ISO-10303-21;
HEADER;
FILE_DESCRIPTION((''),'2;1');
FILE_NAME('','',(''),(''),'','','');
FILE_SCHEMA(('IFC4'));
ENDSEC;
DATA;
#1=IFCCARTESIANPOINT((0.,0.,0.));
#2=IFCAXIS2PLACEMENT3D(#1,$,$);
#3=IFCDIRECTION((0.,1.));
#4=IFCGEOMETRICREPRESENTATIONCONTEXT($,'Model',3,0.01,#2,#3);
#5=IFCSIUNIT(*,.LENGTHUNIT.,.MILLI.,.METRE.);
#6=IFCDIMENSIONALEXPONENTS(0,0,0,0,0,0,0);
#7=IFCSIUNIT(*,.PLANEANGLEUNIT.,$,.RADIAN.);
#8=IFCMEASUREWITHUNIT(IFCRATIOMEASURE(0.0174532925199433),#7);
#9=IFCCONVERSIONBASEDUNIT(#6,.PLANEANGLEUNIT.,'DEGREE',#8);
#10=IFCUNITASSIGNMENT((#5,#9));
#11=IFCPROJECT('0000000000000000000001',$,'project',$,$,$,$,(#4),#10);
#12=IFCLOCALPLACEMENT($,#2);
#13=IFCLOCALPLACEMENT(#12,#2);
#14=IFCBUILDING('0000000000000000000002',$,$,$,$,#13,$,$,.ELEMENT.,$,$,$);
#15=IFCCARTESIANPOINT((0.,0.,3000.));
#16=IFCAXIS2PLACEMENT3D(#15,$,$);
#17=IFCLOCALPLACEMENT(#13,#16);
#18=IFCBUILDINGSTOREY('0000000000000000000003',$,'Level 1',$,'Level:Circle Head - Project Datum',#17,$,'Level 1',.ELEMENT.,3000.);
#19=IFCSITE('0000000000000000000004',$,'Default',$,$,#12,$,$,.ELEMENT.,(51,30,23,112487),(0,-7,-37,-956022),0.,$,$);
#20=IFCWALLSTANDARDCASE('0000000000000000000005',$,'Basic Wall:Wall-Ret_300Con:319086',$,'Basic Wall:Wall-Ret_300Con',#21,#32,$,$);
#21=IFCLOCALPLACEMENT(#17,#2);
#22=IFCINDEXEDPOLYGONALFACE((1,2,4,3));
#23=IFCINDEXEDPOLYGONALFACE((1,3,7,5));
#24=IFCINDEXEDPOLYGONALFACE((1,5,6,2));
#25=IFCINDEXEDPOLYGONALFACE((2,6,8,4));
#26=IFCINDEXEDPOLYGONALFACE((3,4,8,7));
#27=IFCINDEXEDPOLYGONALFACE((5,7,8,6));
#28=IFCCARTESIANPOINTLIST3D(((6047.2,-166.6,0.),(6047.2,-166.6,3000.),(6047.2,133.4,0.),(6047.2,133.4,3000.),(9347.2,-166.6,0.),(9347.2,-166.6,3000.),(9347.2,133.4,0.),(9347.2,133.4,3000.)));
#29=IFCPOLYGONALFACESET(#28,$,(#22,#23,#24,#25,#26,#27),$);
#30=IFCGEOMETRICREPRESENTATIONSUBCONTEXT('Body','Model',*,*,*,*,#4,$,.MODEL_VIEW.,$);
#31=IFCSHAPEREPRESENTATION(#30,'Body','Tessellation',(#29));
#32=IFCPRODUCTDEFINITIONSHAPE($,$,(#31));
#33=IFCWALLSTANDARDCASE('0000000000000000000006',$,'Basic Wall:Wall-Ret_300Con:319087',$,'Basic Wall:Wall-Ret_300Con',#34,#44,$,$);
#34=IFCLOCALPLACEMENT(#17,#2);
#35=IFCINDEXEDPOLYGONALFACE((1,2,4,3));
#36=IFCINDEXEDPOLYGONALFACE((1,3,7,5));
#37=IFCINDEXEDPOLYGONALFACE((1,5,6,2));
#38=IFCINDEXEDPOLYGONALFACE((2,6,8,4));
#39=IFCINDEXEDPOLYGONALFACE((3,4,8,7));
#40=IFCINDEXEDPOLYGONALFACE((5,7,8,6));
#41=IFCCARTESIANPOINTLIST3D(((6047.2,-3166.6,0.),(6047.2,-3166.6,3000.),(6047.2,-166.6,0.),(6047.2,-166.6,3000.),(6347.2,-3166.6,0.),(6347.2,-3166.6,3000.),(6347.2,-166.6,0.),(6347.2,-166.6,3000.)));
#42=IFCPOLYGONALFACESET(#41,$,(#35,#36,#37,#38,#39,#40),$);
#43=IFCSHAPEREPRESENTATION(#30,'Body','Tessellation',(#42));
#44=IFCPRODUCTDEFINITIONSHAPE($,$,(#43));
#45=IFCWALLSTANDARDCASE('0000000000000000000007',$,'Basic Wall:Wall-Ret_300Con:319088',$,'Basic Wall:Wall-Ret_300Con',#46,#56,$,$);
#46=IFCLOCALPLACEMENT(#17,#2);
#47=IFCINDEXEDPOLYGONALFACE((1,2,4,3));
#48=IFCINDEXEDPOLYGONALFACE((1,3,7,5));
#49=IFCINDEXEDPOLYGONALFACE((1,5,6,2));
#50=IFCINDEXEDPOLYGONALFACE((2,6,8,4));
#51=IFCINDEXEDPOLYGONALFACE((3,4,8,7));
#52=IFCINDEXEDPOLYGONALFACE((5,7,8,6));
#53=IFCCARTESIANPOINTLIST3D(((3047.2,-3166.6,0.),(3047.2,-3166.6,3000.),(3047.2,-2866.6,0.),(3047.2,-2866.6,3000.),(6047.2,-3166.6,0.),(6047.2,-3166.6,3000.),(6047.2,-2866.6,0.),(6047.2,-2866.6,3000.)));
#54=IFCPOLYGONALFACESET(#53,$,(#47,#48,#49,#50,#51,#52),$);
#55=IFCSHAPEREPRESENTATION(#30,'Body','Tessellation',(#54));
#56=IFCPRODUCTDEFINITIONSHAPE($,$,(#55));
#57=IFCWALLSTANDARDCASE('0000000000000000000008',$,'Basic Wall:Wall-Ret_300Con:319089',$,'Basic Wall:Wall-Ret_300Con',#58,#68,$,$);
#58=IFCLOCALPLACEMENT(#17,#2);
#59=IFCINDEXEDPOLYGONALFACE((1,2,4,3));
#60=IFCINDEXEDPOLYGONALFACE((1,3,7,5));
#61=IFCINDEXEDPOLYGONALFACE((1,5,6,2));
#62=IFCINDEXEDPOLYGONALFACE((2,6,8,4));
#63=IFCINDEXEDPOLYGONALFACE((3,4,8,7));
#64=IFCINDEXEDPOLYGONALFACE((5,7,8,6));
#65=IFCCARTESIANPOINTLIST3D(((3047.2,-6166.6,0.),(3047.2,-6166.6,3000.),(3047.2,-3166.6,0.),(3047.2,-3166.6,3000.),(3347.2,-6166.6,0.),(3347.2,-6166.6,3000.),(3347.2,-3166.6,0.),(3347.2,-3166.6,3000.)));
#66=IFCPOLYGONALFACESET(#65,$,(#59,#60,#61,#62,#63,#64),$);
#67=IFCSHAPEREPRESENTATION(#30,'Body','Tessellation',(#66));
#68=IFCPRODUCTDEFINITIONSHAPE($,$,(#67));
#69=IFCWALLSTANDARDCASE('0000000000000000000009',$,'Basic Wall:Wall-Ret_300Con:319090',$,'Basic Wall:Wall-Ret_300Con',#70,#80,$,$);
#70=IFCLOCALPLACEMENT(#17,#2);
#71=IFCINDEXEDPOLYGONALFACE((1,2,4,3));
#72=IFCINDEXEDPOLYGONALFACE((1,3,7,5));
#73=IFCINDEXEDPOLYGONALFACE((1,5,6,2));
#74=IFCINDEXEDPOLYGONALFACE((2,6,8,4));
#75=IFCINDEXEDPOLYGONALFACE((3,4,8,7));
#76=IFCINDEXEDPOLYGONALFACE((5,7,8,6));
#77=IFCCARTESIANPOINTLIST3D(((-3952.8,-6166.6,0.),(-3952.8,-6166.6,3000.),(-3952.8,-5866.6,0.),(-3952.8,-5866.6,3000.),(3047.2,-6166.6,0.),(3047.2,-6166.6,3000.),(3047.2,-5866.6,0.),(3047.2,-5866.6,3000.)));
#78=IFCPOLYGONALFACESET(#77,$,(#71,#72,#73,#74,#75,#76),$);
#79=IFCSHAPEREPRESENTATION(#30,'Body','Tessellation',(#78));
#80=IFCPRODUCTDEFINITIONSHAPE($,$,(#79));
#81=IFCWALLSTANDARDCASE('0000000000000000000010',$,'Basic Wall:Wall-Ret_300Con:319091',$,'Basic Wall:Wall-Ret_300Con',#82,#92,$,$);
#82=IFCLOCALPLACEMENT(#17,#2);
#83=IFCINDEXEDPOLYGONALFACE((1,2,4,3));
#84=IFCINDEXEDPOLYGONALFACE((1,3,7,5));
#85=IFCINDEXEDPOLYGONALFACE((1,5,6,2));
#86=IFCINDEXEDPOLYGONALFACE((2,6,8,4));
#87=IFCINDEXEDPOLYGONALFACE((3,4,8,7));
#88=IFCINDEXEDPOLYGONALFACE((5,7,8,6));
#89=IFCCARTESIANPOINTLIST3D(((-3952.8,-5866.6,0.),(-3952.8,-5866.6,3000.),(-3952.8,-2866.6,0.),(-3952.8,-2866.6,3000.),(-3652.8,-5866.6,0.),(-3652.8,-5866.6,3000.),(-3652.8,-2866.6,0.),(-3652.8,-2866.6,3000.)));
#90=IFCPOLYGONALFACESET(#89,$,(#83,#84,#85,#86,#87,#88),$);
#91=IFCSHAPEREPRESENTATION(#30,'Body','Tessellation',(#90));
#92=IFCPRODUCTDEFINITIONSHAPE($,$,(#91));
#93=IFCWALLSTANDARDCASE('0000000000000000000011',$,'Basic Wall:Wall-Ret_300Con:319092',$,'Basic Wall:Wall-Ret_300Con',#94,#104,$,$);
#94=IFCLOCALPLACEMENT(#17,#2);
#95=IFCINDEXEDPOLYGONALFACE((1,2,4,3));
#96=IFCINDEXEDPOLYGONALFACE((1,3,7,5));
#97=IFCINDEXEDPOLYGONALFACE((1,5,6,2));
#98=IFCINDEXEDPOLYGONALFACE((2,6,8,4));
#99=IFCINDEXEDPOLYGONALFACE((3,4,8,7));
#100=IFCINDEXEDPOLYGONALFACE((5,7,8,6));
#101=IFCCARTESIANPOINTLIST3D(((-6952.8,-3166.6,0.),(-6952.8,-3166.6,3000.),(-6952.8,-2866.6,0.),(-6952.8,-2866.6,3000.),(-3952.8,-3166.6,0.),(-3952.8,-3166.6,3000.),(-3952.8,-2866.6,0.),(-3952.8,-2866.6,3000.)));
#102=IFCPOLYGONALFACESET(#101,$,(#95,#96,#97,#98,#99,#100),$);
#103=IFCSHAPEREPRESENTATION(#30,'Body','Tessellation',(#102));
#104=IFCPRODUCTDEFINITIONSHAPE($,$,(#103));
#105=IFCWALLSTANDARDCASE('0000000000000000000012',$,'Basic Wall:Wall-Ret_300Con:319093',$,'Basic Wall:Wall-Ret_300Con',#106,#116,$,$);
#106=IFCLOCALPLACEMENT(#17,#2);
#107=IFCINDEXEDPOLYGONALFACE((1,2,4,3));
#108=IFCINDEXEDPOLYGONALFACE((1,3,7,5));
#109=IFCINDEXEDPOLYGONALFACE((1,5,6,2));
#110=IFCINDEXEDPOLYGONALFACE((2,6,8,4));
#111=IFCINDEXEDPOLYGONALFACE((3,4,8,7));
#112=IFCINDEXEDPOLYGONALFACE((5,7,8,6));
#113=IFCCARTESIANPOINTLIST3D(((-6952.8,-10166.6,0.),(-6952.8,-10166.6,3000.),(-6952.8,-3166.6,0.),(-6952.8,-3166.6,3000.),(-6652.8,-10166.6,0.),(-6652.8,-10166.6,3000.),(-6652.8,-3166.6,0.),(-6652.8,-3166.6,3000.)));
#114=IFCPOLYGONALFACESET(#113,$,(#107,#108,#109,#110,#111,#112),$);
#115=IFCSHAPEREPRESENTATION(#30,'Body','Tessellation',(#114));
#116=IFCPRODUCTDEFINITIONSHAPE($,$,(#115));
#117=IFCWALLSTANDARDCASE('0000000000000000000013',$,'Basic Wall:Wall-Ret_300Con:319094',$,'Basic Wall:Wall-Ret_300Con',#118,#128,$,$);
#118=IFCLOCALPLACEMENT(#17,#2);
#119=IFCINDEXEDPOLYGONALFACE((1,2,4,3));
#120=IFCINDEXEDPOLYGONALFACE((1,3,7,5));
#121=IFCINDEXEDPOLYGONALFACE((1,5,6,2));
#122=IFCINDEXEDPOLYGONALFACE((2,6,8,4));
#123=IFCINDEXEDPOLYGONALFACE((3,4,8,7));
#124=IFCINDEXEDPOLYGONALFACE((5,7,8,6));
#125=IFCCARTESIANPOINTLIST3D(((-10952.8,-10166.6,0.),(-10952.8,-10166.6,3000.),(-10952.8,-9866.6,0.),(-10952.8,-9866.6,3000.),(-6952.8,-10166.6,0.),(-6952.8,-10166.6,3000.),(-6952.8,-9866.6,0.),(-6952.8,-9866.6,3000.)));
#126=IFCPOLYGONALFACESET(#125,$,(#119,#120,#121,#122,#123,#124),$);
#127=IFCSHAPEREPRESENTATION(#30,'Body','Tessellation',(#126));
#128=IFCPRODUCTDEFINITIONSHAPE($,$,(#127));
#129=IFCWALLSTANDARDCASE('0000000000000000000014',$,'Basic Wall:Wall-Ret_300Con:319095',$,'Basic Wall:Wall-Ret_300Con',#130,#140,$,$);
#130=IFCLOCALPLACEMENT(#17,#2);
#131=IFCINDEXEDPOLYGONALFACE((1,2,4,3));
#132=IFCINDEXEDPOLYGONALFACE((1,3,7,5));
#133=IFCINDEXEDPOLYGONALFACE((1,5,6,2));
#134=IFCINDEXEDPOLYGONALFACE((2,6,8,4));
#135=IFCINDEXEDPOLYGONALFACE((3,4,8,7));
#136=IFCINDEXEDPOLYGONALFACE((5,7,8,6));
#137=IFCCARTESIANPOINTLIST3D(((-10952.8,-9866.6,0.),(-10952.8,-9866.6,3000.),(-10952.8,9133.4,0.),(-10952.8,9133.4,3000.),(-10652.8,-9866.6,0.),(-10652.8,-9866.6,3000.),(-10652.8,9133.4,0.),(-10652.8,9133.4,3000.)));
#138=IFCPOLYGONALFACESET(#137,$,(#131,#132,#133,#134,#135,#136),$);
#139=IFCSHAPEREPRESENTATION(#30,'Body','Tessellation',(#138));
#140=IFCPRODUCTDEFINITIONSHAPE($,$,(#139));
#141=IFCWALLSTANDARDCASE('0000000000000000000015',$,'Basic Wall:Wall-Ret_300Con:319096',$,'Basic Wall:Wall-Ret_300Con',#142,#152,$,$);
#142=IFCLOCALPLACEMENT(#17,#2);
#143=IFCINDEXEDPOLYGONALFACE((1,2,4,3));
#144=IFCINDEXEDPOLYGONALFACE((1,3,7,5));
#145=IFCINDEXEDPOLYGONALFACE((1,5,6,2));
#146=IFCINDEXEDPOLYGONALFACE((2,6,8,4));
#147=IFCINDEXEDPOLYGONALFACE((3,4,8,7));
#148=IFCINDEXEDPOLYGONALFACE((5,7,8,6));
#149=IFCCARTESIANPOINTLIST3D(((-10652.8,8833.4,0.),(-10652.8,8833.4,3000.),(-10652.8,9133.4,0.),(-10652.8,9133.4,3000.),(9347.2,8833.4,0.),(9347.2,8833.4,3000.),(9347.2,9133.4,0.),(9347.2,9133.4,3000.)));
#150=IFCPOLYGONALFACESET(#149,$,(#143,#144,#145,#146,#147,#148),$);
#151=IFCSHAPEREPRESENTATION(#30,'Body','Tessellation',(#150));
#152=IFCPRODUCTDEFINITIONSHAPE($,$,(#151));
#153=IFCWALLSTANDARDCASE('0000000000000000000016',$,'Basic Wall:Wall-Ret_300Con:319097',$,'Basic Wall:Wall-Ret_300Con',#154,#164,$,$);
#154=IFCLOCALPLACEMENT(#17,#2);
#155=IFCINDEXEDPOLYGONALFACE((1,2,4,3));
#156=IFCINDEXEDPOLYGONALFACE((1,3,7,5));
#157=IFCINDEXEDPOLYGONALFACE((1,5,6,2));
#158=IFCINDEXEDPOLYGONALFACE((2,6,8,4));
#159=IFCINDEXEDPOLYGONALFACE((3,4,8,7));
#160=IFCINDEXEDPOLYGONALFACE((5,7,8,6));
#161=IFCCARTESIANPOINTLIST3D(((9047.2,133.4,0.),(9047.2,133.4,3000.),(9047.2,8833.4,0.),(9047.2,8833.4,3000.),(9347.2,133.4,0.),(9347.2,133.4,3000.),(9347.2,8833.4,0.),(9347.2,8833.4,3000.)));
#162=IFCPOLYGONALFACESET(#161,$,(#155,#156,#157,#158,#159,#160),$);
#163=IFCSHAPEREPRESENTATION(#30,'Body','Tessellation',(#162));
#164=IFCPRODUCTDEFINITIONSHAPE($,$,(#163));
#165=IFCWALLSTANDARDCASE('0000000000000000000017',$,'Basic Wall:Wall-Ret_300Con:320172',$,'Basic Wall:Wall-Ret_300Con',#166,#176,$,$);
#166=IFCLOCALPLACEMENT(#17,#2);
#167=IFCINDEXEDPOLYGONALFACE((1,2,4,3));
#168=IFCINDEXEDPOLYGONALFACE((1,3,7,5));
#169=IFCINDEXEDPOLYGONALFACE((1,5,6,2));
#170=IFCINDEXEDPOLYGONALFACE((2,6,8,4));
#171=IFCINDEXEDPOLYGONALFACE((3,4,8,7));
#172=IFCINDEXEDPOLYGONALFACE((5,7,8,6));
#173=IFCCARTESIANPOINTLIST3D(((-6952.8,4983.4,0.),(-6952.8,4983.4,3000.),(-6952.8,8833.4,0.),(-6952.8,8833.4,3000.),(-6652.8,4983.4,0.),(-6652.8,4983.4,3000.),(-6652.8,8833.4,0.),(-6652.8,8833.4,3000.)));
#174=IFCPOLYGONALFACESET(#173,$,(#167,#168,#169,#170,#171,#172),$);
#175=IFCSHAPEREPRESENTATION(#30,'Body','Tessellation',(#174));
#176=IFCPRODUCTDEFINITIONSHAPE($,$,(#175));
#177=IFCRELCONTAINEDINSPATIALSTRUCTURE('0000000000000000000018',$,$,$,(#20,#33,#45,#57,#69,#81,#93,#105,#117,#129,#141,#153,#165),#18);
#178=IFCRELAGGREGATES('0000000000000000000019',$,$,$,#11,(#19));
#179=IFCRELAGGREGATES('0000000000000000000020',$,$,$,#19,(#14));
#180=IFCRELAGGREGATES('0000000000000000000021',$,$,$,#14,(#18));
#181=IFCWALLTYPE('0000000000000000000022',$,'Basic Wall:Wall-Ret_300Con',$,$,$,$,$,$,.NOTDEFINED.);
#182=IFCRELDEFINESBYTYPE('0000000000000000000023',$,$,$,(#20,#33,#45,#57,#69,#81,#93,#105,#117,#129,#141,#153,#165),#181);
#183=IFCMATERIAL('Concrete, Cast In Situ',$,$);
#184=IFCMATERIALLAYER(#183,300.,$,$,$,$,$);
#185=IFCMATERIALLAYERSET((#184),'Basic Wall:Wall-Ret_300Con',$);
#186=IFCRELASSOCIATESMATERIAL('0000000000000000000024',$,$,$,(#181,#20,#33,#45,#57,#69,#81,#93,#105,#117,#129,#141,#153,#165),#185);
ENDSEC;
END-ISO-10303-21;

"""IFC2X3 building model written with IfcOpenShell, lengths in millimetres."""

from ifc_helpers import new_model, entity, si_unit, converted_unit, direction, frame, frame_2d, origin, place, context, subcontext, project, spatial, rectangle, extrude, material, layer, layer_set, layer_usage, type_object, element, save


model = new_model("IFC2X3")

# Units and contexts
model_context = context("Model", 3, precision=0.01, world=origin(), true_north=direction((0.0, 1.0)))
body_context = subcontext(model_context, "Body", "Model", "MODEL_VIEW")
ifc_project = project(units=[si_unit("LENGTHUNIT", "METRE", prefix="MILLI"), converted_unit("PLANEANGLEUNIT", "DEGREE", entity("IfcRatioMeasure", 0.0174532925199433), si_unit("PLANEANGLEUNIT", "RADIAN"), dimensions=[0, 0, 0, 0, 0, 0, 0])], contexts=[model_context])

# Site, building, storey
site_placement = place(None, origin())
site = spatial("IfcSite", under=ifc_project, at=site_placement, Name="Default", CompositionType="ELEMENT", RefLatitude=(51, 30, 23, 112487), RefLongitude=(0, -7, -37, -956022), RefElevation=0.0)
building_placement = place(site_placement, origin())
building = spatial("IfcBuilding", under=site, at=building_placement, CompositionType="ELEMENT")
storey_placement = place(building_placement, frame((0.0, 0.0, 3000.0)))
storey = spatial("IfcBuildingStorey", under=building, at=storey_placement, Name="Level 1", ObjectType="Level:Circle Head - Project Datum", LongName="Level 1", CompositionType="ELEMENT", Elevation=3000.0)

# Walls
ifc_material_1 = material(Name="Concrete, Cast In Situ")
ifc_layer_1 = layer(ifc_material_1, 300.0)
ifc_layer_set_1 = layer_set([ifc_layer_1], Name="Basic Wall:Wall-Ret_300Con")
ifc_layer_usage_1 = layer_usage(ifc_layer_set_1, "AXIS2", "NEGATIVE", 150.0)
wall_type = type_object("IfcWallType", Name="Basic Wall:Wall-Ret_300Con", PredefinedType="NOTDEFINED", material=ifc_layer_set_1)
wall_1_placement = place(storey_placement, frame((9347.2, -16.6, 0.0), z_axis=(0.0, 0.0, 1.0), x_axis=(-1.0, 0.0, 0.0)))
element("IfcWallStandardCase", 1, at=wall_1_placement, inside=storey, type_object=wall_type, material=ifc_layer_usage_1, Name="Basic Wall:Wall-Ret_300Con:319086", ObjectType="Basic Wall:Wall-Ret_300Con", context=body_context, shape_type="SweptSolid", body=[
    extrude(rectangle(XDim=3300.0, YDim=300.0, at=frame_2d((1650.0, 0.0), x_axis=(-1.0, 0.0))), origin(), (0.0, 0.0, 1.0), 3000.0),
])
ifc_layer_usage_2 = layer_usage(ifc_layer_set_1, "AXIS2", "NEGATIVE", 150.0)
wall_2_placement = place(storey_placement, frame((6197.2, -166.6, 0.0), z_axis=(0.0, 0.0, 1.0), x_axis=(0.0, -1.0, 0.0)))
element("IfcWallStandardCase", 2, at=wall_2_placement, inside=storey, type_object=wall_type, material=ifc_layer_usage_2, Name="Basic Wall:Wall-Ret_300Con:319087", ObjectType="Basic Wall:Wall-Ret_300Con", context=body_context, shape_type="SweptSolid", body=[
    extrude(rectangle(XDim=3000.0, YDim=300.0, at=frame_2d((1500.0, 0.0), x_axis=(-1.0, 0.0))), origin(), (0.0, 0.0, 1.0), 3000.0),
])
ifc_layer_usage_3 = layer_usage(ifc_layer_set_1, "AXIS2", "NEGATIVE", 150.0)
wall_3_placement = place(storey_placement, frame((6047.2, -3016.6, 0.0), z_axis=(0.0, 0.0, 1.0), x_axis=(-1.0, 0.0, 0.0)))
element("IfcWallStandardCase", 3, at=wall_3_placement, inside=storey, type_object=wall_type, material=ifc_layer_usage_3, Name="Basic Wall:Wall-Ret_300Con:319088", ObjectType="Basic Wall:Wall-Ret_300Con", context=body_context, shape_type="SweptSolid", body=[
    extrude(rectangle(XDim=3000.0, YDim=300.0, at=frame_2d((1500.0, 0.0), x_axis=(-1.0, 0.0))), origin(), (0.0, 0.0, 1.0), 3000.0),
])
ifc_layer_usage_4 = layer_usage(ifc_layer_set_1, "AXIS2", "NEGATIVE", 150.0)
wall_4_placement = place(storey_placement, frame((3197.2, -3166.6, 0.0), z_axis=(0.0, 0.0, 1.0), x_axis=(0.0, -1.0, 0.0)))
element("IfcWallStandardCase", 4, at=wall_4_placement, inside=storey, type_object=wall_type, material=ifc_layer_usage_4, Name="Basic Wall:Wall-Ret_300Con:319089", ObjectType="Basic Wall:Wall-Ret_300Con", context=body_context, shape_type="SweptSolid", body=[
    extrude(rectangle(XDim=3000.0, YDim=300.0, at=frame_2d((1500.0, 0.0), x_axis=(-1.0, 0.0))), origin(), (0.0, 0.0, 1.0), 3000.0),
])
ifc_layer_usage_5 = layer_usage(ifc_layer_set_1, "AXIS2", "NEGATIVE", 150.0)
wall_5_placement = place(storey_placement, frame((3047.2, -6016.6, 0.0), z_axis=(0.0, 0.0, 1.0), x_axis=(-1.0, 0.0, 0.0)))
element("IfcWallStandardCase", 5, at=wall_5_placement, inside=storey, type_object=wall_type, material=ifc_layer_usage_5, Name="Basic Wall:Wall-Ret_300Con:319090", ObjectType="Basic Wall:Wall-Ret_300Con", context=body_context, shape_type="SweptSolid", body=[
    extrude(rectangle(XDim=7000.0, YDim=300.0, at=frame_2d((3500.0, 0.0), x_axis=(-1.0, 0.0))), origin(), (0.0, 0.0, 1.0), 3000.0),
])
ifc_layer_usage_6 = layer_usage(ifc_layer_set_1, "AXIS2", "NEGATIVE", 150.0)
wall_6_placement = place(storey_placement, frame((-3802.8, -5866.6, 0.0), z_axis=(0.0, 0.0, 1.0), x_axis=(0.0, 1.0, 0.0)))
element("IfcWallStandardCase", 6, at=wall_6_placement, inside=storey, type_object=wall_type, material=ifc_layer_usage_6, Name="Basic Wall:Wall-Ret_300Con:319091", ObjectType="Basic Wall:Wall-Ret_300Con", context=body_context, shape_type="SweptSolid", body=[
    extrude(rectangle(XDim=3000.0, YDim=300.0, at=frame_2d((1500.0, 0.0), x_axis=(-1.0, 0.0))), origin(), (0.0, 0.0, 1.0), 3000.0),
])
ifc_layer_usage_7 = layer_usage(ifc_layer_set_1, "AXIS2", "NEGATIVE", 150.0)
wall_7_placement = place(storey_placement, frame((-3952.8, -3016.6, 0.0), z_axis=(0.0, 0.0, 1.0), x_axis=(-1.0, 0.0, 0.0)))
element("IfcWallStandardCase", 7, at=wall_7_placement, inside=storey, type_object=wall_type, material=ifc_layer_usage_7, Name="Basic Wall:Wall-Ret_300Con:319092", ObjectType="Basic Wall:Wall-Ret_300Con", context=body_context, shape_type="SweptSolid", body=[
    extrude(rectangle(XDim=3000.0, YDim=300.0, at=frame_2d((1500.0, 0.0), x_axis=(-1.0, 0.0))), origin(), (0.0, 0.0, 1.0), 3000.0),
])
ifc_layer_usage_8 = layer_usage(ifc_layer_set_1, "AXIS2", "NEGATIVE", 150.0)
wall_8_placement = place(storey_placement, frame((-6802.8, -3166.6, 0.0), z_axis=(0.0, 0.0, 1.0), x_axis=(0.0, -1.0, 0.0)))
element("IfcWallStandardCase", 8, at=wall_8_placement, inside=storey, type_object=wall_type, material=ifc_layer_usage_8, Name="Basic Wall:Wall-Ret_300Con:319093", ObjectType="Basic Wall:Wall-Ret_300Con", context=body_context, shape_type="SweptSolid", body=[
    extrude(rectangle(XDim=7000.0, YDim=300.0, at=frame_2d((3500.0, 0.0), x_axis=(-1.0, 0.0))), origin(), (0.0, 0.0, 1.0), 3000.0),
])
ifc_layer_usage_9 = layer_usage(ifc_layer_set_1, "AXIS2", "NEGATIVE", 150.0)
wall_9_placement = place(storey_placement, frame((-6952.8, -10016.6, 0.0), z_axis=(0.0, 0.0, 1.0), x_axis=(-1.0, 0.0, 0.0)))
element("IfcWallStandardCase", 9, at=wall_9_placement, inside=storey, type_object=wall_type, material=ifc_layer_usage_9, Name="Basic Wall:Wall-Ret_300Con:319094", ObjectType="Basic Wall:Wall-Ret_300Con", context=body_context, shape_type="SweptSolid", body=[
    extrude(rectangle(XDim=4000.0, YDim=300.0, at=frame_2d((2000.0, 0.0), x_axis=(-1.0, 0.0))), origin(), (0.0, 0.0, 1.0), 3000.0),
])
ifc_layer_usage_10 = layer_usage(ifc_layer_set_1, "AXIS2", "NEGATIVE", 150.0)
wall_10_placement = place(storey_placement, frame((-10802.8, -9866.6, 0.0), z_axis=(0.0, 0.0, 1.0), x_axis=(0.0, 1.0, 0.0)))
element("IfcWallStandardCase", 10, at=wall_10_placement, inside=storey, type_object=wall_type, material=ifc_layer_usage_10, Name="Basic Wall:Wall-Ret_300Con:319095", ObjectType="Basic Wall:Wall-Ret_300Con", context=body_context, shape_type="SweptSolid", body=[
    extrude(rectangle(XDim=19000.0, YDim=300.0, at=frame_2d((9500.0, 0.0), x_axis=(-1.0, 0.0))), origin(), (0.0, 0.0, 1.0), 3000.0),
])
ifc_layer_usage_11 = layer_usage(ifc_layer_set_1, "AXIS2", "NEGATIVE", 150.0)
wall_11_placement = place(storey_placement, frame((-10652.8, 8983.4, 0.0)))
element("IfcWallStandardCase", 11, at=wall_11_placement, inside=storey, type_object=wall_type, material=ifc_layer_usage_11, Name="Basic Wall:Wall-Ret_300Con:319096", ObjectType="Basic Wall:Wall-Ret_300Con", context=body_context, shape_type="SweptSolid", body=[
    extrude(rectangle(XDim=20000.0, YDim=300.0, at=frame_2d((10000.0, 0.0), x_axis=(-1.0, 0.0))), origin(), (0.0, 0.0, 1.0), 3000.0),
])
ifc_layer_usage_12 = layer_usage(ifc_layer_set_1, "AXIS2", "NEGATIVE", 150.0)
wall_12_placement = place(storey_placement, frame((9197.2, 8833.4, 0.0), z_axis=(0.0, 0.0, 1.0), x_axis=(0.0, -1.0, 0.0)))
element("IfcWallStandardCase", 12, at=wall_12_placement, inside=storey, type_object=wall_type, material=ifc_layer_usage_12, Name="Basic Wall:Wall-Ret_300Con:319097", ObjectType="Basic Wall:Wall-Ret_300Con", context=body_context, shape_type="SweptSolid", body=[
    extrude(rectangle(XDim=8700.0, YDim=300.0, at=frame_2d((4350.0, 0.0), x_axis=(-1.0, 0.0))), origin(), (0.0, 0.0, 1.0), 3000.0),
])
ifc_layer_usage_13 = layer_usage(ifc_layer_set_1, "AXIS2", "NEGATIVE", 150.0)
wall_13_placement = place(storey_placement, frame((-6802.8, 4983.4, 0.0), z_axis=(0.0, 0.0, 1.0), x_axis=(0.0, 1.0, 0.0)))
element("IfcWallStandardCase", 13, at=wall_13_placement, inside=storey, type_object=wall_type, material=ifc_layer_usage_13, Name="Basic Wall:Wall-Ret_300Con:320172", ObjectType="Basic Wall:Wall-Ret_300Con", context=body_context, shape_type="SweptSolid", body=[
    extrude(rectangle(XDim=3850.0, YDim=300.0, at=frame_2d((1925.0, 0.0), x_axis=(-1.0, 0.0))), origin(), (0.0, 0.0, 1.0), 3000.0),
])

save(model, "model.ifc")
